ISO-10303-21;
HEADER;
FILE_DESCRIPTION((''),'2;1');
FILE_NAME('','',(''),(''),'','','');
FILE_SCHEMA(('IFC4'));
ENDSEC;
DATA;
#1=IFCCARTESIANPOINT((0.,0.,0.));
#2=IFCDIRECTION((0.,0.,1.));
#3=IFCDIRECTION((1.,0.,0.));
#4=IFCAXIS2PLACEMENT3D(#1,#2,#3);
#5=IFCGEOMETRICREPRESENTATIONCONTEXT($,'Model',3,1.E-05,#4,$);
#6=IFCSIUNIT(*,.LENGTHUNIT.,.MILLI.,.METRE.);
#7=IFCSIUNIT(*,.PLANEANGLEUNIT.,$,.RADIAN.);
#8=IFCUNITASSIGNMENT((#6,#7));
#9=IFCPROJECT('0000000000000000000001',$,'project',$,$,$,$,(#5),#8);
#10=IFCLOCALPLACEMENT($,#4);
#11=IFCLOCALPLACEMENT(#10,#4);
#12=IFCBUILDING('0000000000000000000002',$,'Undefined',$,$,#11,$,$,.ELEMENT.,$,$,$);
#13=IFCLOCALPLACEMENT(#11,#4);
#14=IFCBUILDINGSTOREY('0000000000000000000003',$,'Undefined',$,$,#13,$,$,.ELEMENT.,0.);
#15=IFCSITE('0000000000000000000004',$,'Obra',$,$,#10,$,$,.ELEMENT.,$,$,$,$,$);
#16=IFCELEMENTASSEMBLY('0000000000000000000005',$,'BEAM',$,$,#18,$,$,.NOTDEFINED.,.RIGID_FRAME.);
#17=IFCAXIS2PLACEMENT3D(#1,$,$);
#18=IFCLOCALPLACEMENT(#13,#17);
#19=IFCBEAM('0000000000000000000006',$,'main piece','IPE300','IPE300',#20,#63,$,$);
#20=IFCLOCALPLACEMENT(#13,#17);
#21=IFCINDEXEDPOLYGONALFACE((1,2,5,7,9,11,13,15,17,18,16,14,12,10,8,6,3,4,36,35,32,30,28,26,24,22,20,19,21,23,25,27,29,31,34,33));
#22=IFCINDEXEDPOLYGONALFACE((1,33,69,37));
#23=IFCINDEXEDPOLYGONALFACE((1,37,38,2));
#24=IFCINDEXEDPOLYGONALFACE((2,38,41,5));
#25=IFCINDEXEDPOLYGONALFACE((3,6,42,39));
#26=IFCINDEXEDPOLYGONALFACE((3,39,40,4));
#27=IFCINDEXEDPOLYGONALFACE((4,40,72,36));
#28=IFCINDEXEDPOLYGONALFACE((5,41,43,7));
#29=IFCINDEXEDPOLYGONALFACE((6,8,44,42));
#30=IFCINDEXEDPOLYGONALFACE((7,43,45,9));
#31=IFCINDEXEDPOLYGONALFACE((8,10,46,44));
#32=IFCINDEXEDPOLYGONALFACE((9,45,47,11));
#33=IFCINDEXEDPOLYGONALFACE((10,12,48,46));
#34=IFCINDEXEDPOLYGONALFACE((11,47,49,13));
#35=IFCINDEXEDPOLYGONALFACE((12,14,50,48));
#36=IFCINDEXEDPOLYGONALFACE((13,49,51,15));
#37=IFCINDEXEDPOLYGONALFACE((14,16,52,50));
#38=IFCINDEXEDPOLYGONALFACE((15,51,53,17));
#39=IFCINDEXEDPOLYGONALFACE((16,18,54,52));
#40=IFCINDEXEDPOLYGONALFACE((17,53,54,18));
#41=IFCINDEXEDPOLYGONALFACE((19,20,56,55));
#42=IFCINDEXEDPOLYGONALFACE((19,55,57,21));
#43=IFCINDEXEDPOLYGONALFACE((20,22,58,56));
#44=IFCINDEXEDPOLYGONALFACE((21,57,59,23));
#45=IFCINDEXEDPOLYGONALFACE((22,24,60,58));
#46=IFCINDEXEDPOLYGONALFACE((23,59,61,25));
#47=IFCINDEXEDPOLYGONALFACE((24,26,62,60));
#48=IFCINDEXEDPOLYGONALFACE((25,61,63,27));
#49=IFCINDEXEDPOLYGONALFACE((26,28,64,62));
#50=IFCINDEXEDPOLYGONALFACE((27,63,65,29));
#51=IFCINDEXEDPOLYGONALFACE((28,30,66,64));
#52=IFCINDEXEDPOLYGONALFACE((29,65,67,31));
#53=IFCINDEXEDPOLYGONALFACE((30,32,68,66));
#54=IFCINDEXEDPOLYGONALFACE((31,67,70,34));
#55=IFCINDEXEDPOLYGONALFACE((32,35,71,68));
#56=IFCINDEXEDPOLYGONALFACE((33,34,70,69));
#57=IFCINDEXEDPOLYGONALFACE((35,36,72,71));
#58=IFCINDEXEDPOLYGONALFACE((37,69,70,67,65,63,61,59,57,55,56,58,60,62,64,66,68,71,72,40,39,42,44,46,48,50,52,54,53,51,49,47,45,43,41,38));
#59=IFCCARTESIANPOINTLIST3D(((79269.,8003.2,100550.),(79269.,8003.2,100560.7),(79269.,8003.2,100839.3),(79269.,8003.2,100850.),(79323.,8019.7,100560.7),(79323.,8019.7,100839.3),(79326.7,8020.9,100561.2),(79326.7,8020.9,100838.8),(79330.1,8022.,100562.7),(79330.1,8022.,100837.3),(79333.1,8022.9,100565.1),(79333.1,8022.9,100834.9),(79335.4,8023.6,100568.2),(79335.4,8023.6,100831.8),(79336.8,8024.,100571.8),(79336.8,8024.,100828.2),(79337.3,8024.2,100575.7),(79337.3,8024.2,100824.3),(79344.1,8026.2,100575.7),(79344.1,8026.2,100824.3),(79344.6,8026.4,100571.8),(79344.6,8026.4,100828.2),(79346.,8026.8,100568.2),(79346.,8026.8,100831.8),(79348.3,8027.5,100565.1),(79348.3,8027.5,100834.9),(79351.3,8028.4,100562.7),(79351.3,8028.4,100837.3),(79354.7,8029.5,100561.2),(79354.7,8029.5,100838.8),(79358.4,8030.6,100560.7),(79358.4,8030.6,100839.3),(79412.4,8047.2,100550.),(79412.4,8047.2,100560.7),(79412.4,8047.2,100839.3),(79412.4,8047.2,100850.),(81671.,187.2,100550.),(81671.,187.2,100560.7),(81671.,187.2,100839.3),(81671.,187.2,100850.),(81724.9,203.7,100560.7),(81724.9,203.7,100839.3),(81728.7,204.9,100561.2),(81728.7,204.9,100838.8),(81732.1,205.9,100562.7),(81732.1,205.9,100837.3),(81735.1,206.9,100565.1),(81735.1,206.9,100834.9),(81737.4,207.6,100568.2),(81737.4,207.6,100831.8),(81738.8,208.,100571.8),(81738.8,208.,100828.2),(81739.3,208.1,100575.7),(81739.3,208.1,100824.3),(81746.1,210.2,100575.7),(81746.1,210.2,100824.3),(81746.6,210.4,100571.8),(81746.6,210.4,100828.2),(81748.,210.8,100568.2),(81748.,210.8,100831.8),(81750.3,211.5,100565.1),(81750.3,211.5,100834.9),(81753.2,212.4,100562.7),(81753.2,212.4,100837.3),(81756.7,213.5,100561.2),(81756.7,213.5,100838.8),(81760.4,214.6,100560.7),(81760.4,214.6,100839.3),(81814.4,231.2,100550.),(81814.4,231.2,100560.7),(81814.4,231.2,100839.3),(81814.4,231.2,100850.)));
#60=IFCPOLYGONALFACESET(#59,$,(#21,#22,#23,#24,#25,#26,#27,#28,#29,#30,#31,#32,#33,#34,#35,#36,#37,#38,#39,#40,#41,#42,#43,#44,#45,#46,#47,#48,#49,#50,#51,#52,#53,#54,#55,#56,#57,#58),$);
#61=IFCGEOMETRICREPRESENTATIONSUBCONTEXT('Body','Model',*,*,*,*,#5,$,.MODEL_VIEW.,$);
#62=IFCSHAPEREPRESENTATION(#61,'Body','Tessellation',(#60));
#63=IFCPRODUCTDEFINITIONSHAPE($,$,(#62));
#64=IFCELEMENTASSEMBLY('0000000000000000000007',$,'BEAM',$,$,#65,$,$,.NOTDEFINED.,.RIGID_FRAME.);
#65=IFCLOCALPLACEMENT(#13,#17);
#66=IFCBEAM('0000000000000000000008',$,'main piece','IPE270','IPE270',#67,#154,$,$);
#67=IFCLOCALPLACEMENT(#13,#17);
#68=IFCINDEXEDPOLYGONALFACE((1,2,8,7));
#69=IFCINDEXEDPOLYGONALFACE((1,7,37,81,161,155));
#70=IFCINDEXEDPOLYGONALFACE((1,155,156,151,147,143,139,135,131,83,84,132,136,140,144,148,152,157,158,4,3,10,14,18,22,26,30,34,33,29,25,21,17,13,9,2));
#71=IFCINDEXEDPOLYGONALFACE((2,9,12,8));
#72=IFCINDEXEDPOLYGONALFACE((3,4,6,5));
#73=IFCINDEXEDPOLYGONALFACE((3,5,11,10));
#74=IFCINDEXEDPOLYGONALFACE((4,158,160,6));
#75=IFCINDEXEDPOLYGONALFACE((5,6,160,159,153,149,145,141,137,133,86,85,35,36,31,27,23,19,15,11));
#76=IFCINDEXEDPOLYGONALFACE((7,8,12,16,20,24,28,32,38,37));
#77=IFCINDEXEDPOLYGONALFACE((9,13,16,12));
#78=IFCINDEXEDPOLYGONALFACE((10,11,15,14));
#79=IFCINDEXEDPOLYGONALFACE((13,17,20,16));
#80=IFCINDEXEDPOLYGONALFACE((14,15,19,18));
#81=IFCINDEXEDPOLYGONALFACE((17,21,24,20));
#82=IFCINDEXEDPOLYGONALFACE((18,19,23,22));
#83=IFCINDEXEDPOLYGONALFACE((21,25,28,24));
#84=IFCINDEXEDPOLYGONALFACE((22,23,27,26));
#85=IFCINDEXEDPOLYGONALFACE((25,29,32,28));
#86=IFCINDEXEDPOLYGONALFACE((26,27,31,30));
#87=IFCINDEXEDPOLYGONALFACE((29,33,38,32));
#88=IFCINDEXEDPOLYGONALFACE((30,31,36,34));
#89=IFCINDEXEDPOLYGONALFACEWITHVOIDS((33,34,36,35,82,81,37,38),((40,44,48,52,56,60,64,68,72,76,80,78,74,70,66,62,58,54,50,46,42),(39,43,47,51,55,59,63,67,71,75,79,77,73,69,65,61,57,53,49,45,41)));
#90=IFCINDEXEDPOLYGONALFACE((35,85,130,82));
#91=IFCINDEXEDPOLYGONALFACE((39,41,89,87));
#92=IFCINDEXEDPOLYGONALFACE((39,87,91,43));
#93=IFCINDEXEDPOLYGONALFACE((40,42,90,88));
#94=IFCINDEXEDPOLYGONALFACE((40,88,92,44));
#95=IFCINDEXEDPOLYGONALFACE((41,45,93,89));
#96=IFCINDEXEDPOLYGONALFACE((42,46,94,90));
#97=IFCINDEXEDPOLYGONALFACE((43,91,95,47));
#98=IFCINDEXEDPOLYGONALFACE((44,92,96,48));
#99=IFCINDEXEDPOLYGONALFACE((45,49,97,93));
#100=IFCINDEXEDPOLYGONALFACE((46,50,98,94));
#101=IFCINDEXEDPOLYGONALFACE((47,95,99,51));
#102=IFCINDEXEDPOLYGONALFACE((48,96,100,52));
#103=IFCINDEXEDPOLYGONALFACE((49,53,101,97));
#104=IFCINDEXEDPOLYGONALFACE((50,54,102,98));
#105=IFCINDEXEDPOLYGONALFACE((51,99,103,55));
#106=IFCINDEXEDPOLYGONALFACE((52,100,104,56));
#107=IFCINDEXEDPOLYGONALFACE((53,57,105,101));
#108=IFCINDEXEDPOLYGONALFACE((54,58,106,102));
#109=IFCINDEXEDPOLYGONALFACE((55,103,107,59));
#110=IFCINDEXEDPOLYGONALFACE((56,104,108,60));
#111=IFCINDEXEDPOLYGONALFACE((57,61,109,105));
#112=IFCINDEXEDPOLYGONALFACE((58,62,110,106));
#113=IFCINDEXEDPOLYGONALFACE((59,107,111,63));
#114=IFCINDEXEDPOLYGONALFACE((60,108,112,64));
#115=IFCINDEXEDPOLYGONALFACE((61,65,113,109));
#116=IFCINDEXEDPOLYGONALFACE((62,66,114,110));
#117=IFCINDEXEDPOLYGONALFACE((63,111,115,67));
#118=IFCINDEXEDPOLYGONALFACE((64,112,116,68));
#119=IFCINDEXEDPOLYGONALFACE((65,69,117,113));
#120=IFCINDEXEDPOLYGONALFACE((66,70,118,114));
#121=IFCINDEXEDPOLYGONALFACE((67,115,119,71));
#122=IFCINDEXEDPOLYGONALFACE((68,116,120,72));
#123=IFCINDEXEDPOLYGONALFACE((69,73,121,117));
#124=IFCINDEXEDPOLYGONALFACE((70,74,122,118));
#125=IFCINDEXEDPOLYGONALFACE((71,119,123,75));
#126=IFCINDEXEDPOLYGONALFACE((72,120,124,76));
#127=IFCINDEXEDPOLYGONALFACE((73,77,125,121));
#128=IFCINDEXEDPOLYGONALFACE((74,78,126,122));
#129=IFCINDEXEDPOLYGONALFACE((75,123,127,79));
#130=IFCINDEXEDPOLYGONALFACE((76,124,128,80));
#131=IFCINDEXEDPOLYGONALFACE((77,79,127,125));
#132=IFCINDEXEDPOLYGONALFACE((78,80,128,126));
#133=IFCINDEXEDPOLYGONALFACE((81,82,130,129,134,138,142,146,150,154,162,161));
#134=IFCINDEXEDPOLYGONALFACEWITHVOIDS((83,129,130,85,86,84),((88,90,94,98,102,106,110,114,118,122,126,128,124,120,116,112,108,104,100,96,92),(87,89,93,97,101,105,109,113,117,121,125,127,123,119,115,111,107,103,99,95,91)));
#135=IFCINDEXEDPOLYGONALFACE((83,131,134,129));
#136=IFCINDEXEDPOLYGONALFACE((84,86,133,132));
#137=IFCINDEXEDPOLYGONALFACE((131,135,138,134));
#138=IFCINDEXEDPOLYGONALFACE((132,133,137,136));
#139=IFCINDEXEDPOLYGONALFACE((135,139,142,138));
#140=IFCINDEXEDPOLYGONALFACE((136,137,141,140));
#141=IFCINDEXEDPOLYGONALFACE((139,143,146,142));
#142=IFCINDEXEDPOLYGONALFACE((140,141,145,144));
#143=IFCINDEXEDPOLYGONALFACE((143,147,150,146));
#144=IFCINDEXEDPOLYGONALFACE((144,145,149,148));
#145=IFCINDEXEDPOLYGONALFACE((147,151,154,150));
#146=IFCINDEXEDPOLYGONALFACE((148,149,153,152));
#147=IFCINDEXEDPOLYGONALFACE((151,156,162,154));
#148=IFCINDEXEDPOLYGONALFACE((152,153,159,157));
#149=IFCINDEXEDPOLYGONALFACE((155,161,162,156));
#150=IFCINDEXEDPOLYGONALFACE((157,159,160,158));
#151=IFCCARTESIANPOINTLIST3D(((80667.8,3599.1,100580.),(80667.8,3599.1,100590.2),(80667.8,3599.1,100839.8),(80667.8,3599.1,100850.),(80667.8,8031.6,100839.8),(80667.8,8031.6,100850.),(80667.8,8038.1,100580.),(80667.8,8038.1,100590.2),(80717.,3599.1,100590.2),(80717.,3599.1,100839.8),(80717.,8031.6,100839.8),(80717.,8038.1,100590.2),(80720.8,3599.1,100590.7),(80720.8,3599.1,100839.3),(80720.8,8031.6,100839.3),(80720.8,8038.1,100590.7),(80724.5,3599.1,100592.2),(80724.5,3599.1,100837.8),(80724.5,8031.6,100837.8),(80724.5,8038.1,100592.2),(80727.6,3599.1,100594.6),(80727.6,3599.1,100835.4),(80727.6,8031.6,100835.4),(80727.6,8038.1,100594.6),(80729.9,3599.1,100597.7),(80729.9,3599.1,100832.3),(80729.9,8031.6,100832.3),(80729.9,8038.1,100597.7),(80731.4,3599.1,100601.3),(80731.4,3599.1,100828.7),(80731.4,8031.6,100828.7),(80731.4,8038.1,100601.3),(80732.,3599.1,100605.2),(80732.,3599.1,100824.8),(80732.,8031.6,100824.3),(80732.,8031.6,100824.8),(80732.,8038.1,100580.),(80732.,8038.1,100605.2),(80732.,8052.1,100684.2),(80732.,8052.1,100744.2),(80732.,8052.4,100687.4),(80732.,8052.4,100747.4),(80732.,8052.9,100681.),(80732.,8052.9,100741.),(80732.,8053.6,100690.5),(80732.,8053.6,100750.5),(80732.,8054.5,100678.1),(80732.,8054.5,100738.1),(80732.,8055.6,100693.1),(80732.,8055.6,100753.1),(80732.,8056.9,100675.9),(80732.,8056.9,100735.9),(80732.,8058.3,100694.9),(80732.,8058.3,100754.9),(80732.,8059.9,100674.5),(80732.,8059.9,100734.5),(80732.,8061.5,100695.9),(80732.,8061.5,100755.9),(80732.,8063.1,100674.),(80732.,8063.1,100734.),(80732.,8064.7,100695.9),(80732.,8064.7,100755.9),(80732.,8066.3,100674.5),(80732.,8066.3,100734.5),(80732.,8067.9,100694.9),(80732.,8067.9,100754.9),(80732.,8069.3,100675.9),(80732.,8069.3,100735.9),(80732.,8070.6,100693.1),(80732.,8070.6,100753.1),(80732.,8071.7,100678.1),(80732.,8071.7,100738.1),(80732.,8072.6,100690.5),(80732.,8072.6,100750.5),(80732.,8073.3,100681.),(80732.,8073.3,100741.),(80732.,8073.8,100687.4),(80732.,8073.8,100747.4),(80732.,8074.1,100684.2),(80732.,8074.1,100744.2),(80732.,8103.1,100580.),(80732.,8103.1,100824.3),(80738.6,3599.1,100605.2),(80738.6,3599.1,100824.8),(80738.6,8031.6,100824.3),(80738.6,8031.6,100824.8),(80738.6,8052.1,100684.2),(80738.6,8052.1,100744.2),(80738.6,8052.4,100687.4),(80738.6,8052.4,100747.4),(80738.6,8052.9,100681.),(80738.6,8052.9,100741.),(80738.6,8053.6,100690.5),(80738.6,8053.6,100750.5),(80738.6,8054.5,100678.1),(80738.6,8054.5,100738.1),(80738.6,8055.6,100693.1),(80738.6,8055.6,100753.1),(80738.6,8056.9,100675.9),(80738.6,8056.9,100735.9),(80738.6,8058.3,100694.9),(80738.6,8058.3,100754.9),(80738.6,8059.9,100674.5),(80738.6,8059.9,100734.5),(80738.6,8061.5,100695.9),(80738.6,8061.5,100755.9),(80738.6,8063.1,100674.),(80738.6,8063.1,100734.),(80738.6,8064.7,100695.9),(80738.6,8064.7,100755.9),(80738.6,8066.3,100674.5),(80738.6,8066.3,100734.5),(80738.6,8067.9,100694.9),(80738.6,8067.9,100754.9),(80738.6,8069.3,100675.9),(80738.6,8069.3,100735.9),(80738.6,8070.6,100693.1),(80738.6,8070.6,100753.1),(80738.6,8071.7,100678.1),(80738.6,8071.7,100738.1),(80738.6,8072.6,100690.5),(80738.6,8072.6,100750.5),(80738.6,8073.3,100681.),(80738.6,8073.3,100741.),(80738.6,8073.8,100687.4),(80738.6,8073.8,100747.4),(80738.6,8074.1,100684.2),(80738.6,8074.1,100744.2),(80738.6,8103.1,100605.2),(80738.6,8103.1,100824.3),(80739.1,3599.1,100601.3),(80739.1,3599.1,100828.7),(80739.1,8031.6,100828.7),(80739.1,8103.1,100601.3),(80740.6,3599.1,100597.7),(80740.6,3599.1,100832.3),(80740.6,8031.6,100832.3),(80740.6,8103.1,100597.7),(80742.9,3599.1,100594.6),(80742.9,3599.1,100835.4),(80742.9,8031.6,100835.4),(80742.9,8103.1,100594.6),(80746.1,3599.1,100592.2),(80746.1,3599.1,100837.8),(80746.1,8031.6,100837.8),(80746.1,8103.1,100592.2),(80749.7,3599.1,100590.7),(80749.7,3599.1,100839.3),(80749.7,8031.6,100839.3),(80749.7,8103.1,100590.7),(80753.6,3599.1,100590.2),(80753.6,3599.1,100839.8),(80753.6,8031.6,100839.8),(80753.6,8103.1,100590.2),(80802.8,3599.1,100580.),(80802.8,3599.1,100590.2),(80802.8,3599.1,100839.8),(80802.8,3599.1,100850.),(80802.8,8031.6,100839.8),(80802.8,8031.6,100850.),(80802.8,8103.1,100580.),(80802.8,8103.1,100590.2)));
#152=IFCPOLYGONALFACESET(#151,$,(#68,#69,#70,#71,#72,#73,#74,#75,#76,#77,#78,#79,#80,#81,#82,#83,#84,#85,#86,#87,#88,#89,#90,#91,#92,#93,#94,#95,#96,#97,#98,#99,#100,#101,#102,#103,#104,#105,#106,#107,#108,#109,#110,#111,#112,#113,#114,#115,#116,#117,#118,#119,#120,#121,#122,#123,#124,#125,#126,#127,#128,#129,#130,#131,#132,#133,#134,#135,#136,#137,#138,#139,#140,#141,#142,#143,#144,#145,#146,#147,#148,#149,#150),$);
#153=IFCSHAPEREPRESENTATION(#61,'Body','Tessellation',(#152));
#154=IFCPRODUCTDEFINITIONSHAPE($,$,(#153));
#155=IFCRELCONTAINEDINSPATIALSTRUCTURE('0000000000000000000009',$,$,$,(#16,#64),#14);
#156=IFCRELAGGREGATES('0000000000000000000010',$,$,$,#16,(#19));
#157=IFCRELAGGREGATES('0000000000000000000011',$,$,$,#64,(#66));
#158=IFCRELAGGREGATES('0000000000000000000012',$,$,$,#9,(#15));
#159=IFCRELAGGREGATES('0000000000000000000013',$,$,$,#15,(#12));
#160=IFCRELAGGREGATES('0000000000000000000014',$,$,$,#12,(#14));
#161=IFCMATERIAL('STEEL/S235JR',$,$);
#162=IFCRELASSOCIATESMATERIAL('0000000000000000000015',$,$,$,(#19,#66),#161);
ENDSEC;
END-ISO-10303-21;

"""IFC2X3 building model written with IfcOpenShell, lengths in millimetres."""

from ifc_helpers import new_model, si_unit, frame, origin_with_axes, origin_2d_with_axis, place, context, subcontext, project, spatial, rectangle, circle, i_section, extrude, clip, halfspace, source, transform, mapped, material, element, aggregate, save


model = new_model("IFC2X3")

# Units and contexts
model_context = context("Model", 3, precision=1e-05, world=origin_with_axes())
body_context = subcontext(model_context, "Body", "Model", "MODEL_VIEW")
ifc_project = project(units=[si_unit("LENGTHUNIT", "METRE", prefix="MILLI"), si_unit("PLANEANGLEUNIT", "RADIAN")], contexts=[model_context])

# Site, building, storey
site_placement = place(None, origin_with_axes())
site = spatial("IfcSite", under=ifc_project, at=site_placement, Name="Obra", CompositionType="ELEMENT")
building_placement = place(site_placement, origin_with_axes())
building = spatial("IfcBuilding", under=site, at=building_placement, Name="Undefined", CompositionType="ELEMENT")
storey_placement = place(building_placement, origin_with_axes())
storey = spatial("IfcBuildingStorey", under=building, at=storey_placement, Name="Undefined", CompositionType="ELEMENT", Elevation=0.0)

# Shared definitions
ifc_material = material(Name="STEEL/S235JR")

# Element assembly, beam
assembly_1_placement = place(storey_placement, origin_with_axes())
assembly_1 = element("IfcElementAssembly", 1, at=assembly_1_placement, inside=storey, Name="BEAM", AssemblyPlace="NOTDEFINED", PredefinedType="RIGID_FRAME")
beam_1_placement = place(assembly_1_placement, frame((79340.7, 8025.2, 100700.0), z_axis=(0.0, 0.0, 1.0), x_axis=(0.293756, -0.955881, 0.0)))
beam_1 = element("IfcBeam", 2, at=beam_1_placement, material=ifc_material, Name="main piece", Description="IPE300", ObjectType="IPE300", context=body_context, shape_type="SweptSolid", body=[
    extrude(i_section(OverallWidth=150.0, OverallDepth=300.0, WebThickness=7.1, FlangeThickness=10.7, FilletRadius=15.0, at=origin_2d_with_axis()), frame((8176.8, 0.0, 0.0), z_axis=(-1.0, 0.0, 0.0), x_axis=(0.0, -1.0, 0.0)), (0.0, 0.0, 1.0), 8176.8),
])
aggregate(assembly_1, [beam_1])

# Element assembly, beam, openings
assembly_2_placement = place(storey_placement, origin_with_axes())
assembly_2 = element("IfcElementAssembly", 3, at=assembly_2_placement, inside=storey, Name="BEAM", AssemblyPlace="NOTDEFINED", PredefinedType="RIGID_FRAME")
beam_2_placement = place(assembly_2_placement, frame((80735.3, 3599.1, 100715.0), z_axis=(0.0, 0.0, 1.0), x_axis=(0.0, 1.0, 0.0)))
beam_2 = element("IfcBeam", 4, at=beam_2_placement, material=ifc_material, Name="main piece", Description="IPE270", ObjectType="IPE270", context=body_context, shape_type="Clipping", body=[
    clip(extrude(i_section(OverallWidth=135.0, OverallDepth=270.0, WebThickness=6.6, FlangeThickness=10.2, FilletRadius=15.0, at=origin_2d_with_axis()), frame((4504.0, 0.0, 0.0), z_axis=(-1.0, 0.0, 0.0), x_axis=(0.0, -1.0, 0.0)), (0.0, 0.0, 1.0), 4504.0), halfspace(frame((4504.0, 0.0, -235.0), z_axis=(-1.0, 0.0, 0.0), x_axis=(0.0, 1.0, 0.0)), True)),
])
opening_1_placement = place(assembly_2_placement, frame((80735.3, 3599.1, 100715.0), z_axis=(0.0, 0.0, 1.0), x_axis=(0.0, 1.0, 0.0)))
element("IfcOpeningElement", 5, at=opening_1_placement, cuts=beam_2, ObjectType="Recess", context=body_context, shape_type="SweptSolid", body=[
    extrude(rectangle(XDim=75.0, YDim=300.0, at=origin_2d_with_axis()), frame((4476.5, 153.3, 124.3), z_axis=(0.0, 0.0, -1.0), x_axis=(-1.0, 0.0, 0.0)), (0.0, 0.0, 1.0), 278.6),
])
opening_2_placement = place(assembly_2_placement, frame((80735.3, 3599.1, 100715.0), z_axis=(0.0, 0.0, 1.0), x_axis=(0.0, 1.0, 0.0)))
element("IfcOpeningElement", 6, at=opening_2_placement, cuts=beam_2, ObjectType="Recess", context=body_context, shape_type="SweptSolid", body=[
    extrude(rectangle(XDim=26.7, YDim=83.5, at=origin_2d_with_axis()), frame((4474.2, 68.5, 122.7), z_axis=(0.0, -1.0, 0.0), x_axis=(0.0, 0.0, -1.0)), (0.0, 0.0, 1.0), 137.0),
])
shared_shape_1 = source(origin_with_axes(), body_context, "Body", "SweptSolid", [
    extrude(circle(Radius=11.0, at=origin_2d_with_axis()), frame((0.0, -3.4, 0.0), z_axis=(0.0, 1.0, 0.0), x_axis=(1.0, 0.0, 0.0)), (0.0, 0.0, 1.0), 6.8),
])
opening_3_placement = place(assembly_2_placement, frame((80735.3, 8103.1, 100850.0), z_axis=(0.0, -1.0, 0.0), x_axis=(0.0, 0.0, -1.0)))
element("IfcOpeningElement", 7, at=opening_3_placement, cuts=beam_2, ObjectType="Opening", context=body_context, shape_type="MappedRepresentation", body=[
    mapped(shared_shape_1, transform((105.0, 0.0, 40.0))),
    mapped(shared_shape_1, transform((165.0, 0.0, 40.0))),
])
aggregate(assembly_2, [beam_2])

save(model, "model.ifc")
